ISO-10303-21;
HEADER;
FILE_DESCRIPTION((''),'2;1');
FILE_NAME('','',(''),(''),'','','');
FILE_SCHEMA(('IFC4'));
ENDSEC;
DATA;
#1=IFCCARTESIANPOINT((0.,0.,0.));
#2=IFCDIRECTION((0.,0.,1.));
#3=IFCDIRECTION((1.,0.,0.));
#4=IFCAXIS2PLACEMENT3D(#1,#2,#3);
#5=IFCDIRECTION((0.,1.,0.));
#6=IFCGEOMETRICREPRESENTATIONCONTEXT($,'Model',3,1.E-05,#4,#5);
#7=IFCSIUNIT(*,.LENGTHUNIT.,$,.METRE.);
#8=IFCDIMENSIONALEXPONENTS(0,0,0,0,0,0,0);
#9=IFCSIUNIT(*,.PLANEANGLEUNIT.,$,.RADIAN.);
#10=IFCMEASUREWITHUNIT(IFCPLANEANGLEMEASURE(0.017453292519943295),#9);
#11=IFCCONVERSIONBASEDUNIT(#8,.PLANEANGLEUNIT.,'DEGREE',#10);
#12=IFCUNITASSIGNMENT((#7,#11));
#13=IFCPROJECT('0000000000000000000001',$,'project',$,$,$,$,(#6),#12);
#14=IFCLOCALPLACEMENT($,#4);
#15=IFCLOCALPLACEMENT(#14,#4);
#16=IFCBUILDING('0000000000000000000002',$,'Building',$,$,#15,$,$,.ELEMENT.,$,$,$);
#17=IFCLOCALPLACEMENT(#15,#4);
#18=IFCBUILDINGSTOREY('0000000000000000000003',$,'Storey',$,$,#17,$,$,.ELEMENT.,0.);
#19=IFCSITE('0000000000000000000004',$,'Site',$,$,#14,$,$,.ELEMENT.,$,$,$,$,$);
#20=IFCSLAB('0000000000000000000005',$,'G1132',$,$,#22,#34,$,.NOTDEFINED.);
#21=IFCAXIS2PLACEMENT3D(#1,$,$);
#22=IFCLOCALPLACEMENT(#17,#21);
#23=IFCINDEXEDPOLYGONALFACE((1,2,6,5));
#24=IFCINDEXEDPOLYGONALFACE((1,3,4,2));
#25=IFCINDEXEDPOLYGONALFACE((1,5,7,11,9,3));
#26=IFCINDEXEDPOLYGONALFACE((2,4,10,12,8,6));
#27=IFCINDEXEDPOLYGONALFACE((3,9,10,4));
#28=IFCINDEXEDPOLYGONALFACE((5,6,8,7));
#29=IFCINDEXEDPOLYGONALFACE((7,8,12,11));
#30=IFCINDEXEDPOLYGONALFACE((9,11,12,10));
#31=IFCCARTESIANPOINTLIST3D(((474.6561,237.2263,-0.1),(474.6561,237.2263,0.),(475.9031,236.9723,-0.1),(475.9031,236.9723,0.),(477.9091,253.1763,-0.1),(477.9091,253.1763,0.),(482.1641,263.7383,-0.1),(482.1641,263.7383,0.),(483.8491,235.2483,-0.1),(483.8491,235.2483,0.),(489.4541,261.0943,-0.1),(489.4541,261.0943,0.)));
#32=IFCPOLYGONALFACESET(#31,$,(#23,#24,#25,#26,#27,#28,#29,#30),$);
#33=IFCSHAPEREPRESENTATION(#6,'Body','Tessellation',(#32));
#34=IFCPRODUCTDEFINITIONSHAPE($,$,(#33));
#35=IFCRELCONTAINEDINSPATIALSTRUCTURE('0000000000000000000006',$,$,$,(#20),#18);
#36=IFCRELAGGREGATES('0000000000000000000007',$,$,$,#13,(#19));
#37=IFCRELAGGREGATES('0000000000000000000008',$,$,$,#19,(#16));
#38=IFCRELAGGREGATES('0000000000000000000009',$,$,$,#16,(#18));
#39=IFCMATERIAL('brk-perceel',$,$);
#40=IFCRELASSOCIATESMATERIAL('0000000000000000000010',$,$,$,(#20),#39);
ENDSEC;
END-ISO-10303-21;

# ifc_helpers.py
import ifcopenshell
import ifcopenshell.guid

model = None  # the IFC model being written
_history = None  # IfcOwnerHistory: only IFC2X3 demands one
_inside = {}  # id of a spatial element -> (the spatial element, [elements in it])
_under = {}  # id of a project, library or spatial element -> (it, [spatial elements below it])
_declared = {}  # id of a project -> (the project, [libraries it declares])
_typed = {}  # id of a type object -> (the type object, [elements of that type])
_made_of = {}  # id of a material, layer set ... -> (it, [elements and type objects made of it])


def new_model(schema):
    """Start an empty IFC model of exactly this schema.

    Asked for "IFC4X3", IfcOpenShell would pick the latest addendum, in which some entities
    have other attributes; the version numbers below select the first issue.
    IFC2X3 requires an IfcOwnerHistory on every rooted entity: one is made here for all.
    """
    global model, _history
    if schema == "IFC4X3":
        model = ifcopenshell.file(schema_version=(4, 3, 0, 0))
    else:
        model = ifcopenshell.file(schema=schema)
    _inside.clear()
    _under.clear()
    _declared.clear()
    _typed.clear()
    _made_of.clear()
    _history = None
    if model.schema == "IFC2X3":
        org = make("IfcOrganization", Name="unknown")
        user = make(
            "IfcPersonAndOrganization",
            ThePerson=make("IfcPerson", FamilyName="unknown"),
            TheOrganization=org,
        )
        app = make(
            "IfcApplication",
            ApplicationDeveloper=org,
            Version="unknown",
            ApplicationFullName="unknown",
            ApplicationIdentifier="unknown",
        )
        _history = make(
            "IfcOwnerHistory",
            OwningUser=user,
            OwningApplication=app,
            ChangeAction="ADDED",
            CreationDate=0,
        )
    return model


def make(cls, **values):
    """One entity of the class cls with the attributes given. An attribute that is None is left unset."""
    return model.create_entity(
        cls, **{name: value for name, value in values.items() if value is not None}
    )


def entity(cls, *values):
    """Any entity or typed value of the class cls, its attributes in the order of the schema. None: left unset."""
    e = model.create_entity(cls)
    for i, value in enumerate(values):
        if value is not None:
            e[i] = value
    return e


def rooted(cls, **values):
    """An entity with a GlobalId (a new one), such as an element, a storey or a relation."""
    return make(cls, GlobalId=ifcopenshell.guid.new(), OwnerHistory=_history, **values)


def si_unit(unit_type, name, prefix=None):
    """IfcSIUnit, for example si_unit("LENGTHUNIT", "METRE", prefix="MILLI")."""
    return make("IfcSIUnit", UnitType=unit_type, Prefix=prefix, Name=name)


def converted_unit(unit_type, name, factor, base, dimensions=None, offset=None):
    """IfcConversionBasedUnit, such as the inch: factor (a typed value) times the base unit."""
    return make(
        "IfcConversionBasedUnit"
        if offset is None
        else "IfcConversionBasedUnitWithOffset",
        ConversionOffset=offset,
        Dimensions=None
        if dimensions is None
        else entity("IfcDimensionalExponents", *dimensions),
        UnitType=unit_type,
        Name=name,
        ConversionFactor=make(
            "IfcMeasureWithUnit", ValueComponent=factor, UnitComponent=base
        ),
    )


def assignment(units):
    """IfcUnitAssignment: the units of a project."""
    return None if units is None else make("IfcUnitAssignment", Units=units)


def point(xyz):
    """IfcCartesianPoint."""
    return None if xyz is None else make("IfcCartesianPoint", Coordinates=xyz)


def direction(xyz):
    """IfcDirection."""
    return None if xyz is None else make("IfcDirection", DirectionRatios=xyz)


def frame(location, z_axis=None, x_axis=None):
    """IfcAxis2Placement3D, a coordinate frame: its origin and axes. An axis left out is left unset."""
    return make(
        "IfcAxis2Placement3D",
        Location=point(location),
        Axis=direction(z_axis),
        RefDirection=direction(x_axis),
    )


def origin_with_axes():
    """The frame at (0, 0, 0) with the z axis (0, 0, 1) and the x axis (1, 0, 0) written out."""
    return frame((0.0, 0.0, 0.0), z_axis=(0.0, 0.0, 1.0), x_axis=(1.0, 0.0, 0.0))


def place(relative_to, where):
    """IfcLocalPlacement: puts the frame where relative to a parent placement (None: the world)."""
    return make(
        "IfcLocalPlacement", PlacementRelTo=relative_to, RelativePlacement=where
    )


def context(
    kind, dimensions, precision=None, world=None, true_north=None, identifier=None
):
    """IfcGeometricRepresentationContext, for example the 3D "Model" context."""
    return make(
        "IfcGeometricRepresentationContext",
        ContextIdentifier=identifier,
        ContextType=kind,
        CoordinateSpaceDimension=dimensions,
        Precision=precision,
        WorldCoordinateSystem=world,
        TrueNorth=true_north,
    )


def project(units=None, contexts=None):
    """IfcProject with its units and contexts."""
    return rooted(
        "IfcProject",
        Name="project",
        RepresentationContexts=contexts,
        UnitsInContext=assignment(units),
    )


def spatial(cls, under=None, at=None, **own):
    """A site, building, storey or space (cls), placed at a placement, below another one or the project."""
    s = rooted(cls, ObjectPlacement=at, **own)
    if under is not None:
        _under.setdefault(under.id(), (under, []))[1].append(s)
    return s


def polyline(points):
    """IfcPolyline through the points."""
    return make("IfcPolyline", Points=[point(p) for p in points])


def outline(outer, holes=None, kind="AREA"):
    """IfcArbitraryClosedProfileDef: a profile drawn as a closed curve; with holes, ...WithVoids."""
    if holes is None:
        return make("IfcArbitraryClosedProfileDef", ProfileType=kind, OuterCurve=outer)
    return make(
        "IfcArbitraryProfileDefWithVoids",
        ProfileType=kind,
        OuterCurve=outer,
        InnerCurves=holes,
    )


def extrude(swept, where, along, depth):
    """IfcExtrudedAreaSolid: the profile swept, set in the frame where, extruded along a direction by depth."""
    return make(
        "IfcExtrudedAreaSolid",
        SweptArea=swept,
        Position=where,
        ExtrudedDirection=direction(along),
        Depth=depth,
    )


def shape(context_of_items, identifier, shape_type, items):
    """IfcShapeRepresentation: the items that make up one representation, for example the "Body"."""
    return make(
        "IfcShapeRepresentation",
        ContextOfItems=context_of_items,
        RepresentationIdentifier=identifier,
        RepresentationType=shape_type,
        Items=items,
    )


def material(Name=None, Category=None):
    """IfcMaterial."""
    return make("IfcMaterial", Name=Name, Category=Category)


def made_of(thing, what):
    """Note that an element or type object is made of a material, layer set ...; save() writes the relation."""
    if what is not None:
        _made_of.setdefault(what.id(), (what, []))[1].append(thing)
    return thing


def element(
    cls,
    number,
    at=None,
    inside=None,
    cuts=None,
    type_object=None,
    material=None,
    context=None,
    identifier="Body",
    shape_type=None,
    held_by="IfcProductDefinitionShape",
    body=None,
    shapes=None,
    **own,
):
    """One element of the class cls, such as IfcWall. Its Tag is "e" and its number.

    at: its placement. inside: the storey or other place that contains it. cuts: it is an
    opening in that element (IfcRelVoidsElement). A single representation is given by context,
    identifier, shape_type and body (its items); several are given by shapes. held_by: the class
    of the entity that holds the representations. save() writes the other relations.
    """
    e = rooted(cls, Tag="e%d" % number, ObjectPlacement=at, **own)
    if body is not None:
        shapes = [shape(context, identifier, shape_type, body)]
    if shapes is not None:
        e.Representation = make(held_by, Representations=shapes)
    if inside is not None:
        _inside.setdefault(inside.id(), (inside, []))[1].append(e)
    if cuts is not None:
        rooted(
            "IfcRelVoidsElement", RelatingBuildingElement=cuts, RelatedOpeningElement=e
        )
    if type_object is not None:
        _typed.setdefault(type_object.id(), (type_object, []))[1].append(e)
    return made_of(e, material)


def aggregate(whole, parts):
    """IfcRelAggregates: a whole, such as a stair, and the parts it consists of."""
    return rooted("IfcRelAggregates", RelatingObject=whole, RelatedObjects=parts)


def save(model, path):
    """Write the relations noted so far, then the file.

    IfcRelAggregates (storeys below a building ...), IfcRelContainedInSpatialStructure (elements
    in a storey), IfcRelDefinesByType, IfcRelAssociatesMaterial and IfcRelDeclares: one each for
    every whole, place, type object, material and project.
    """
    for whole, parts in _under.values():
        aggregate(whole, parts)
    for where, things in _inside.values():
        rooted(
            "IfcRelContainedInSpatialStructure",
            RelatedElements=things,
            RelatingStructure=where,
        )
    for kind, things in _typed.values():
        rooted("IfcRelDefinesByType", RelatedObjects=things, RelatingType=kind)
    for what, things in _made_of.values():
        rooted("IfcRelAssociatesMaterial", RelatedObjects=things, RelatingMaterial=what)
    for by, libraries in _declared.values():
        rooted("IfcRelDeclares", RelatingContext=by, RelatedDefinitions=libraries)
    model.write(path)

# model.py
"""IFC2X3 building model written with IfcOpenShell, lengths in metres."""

from ifc_helpers import new_model, entity, si_unit, converted_unit, direction, frame, origin_with_axes, place, context, project, spatial, polyline, outline, extrude, material, element, save


model = new_model("IFC2X3")

# Units and contexts
model_context = context("Model", 3, precision=1e-05, world=origin_with_axes(), true_north=direction((0.0, 1.0, 0.0)))
ifc_project = project(units=[si_unit("LENGTHUNIT", "METRE"), converted_unit("PLANEANGLEUNIT", "DEGREE", entity("IfcPlaneAngleMeasure", 0.017453292519943295), si_unit("PLANEANGLEUNIT", "RADIAN"), dimensions=[0, 0, 0, 0, 0, 0, 0])], contexts=[model_context])

# Site, building, storey
site_placement = place(None, origin_with_axes())
site = spatial("IfcSite", under=ifc_project, at=site_placement, Name="Site", CompositionType="ELEMENT")
building_placement = place(site_placement, origin_with_axes())
building = spatial("IfcBuilding", under=site, at=building_placement, Name="Building", CompositionType="ELEMENT")
storey_placement = place(building_placement, origin_with_axes())
storey = spatial("IfcBuildingStorey", under=building, at=storey_placement, Name="Storey", CompositionType="ELEMENT", Elevation=0.0)

# Slab
ifc_material = material(Name="brk-perceel")
slab_1_placement = place(storey_placement, frame((0.0, 0.0, -0.1), z_axis=(0.0, 0.0, 1.0), x_axis=(1.0, 0.0, 0.0)))
element("IfcSlab", 1, at=slab_1_placement, inside=storey, material=ifc_material, Name="G1132", PredefinedType="NOTDEFINED", context=model_context, shape_type="SweptSolid", body=[
    extrude(outline(polyline([(475.9031, 236.9723), (474.6561, 237.2263), (477.9091, 253.1763), (482.1641, 263.7383), (489.4541, 261.0943), (483.8491, 235.2483), (475.9031, 236.9723)])), origin_with_axes(), (0.0, 0.0, 1.0), 0.1),
])

save(model, "model.ifc")
